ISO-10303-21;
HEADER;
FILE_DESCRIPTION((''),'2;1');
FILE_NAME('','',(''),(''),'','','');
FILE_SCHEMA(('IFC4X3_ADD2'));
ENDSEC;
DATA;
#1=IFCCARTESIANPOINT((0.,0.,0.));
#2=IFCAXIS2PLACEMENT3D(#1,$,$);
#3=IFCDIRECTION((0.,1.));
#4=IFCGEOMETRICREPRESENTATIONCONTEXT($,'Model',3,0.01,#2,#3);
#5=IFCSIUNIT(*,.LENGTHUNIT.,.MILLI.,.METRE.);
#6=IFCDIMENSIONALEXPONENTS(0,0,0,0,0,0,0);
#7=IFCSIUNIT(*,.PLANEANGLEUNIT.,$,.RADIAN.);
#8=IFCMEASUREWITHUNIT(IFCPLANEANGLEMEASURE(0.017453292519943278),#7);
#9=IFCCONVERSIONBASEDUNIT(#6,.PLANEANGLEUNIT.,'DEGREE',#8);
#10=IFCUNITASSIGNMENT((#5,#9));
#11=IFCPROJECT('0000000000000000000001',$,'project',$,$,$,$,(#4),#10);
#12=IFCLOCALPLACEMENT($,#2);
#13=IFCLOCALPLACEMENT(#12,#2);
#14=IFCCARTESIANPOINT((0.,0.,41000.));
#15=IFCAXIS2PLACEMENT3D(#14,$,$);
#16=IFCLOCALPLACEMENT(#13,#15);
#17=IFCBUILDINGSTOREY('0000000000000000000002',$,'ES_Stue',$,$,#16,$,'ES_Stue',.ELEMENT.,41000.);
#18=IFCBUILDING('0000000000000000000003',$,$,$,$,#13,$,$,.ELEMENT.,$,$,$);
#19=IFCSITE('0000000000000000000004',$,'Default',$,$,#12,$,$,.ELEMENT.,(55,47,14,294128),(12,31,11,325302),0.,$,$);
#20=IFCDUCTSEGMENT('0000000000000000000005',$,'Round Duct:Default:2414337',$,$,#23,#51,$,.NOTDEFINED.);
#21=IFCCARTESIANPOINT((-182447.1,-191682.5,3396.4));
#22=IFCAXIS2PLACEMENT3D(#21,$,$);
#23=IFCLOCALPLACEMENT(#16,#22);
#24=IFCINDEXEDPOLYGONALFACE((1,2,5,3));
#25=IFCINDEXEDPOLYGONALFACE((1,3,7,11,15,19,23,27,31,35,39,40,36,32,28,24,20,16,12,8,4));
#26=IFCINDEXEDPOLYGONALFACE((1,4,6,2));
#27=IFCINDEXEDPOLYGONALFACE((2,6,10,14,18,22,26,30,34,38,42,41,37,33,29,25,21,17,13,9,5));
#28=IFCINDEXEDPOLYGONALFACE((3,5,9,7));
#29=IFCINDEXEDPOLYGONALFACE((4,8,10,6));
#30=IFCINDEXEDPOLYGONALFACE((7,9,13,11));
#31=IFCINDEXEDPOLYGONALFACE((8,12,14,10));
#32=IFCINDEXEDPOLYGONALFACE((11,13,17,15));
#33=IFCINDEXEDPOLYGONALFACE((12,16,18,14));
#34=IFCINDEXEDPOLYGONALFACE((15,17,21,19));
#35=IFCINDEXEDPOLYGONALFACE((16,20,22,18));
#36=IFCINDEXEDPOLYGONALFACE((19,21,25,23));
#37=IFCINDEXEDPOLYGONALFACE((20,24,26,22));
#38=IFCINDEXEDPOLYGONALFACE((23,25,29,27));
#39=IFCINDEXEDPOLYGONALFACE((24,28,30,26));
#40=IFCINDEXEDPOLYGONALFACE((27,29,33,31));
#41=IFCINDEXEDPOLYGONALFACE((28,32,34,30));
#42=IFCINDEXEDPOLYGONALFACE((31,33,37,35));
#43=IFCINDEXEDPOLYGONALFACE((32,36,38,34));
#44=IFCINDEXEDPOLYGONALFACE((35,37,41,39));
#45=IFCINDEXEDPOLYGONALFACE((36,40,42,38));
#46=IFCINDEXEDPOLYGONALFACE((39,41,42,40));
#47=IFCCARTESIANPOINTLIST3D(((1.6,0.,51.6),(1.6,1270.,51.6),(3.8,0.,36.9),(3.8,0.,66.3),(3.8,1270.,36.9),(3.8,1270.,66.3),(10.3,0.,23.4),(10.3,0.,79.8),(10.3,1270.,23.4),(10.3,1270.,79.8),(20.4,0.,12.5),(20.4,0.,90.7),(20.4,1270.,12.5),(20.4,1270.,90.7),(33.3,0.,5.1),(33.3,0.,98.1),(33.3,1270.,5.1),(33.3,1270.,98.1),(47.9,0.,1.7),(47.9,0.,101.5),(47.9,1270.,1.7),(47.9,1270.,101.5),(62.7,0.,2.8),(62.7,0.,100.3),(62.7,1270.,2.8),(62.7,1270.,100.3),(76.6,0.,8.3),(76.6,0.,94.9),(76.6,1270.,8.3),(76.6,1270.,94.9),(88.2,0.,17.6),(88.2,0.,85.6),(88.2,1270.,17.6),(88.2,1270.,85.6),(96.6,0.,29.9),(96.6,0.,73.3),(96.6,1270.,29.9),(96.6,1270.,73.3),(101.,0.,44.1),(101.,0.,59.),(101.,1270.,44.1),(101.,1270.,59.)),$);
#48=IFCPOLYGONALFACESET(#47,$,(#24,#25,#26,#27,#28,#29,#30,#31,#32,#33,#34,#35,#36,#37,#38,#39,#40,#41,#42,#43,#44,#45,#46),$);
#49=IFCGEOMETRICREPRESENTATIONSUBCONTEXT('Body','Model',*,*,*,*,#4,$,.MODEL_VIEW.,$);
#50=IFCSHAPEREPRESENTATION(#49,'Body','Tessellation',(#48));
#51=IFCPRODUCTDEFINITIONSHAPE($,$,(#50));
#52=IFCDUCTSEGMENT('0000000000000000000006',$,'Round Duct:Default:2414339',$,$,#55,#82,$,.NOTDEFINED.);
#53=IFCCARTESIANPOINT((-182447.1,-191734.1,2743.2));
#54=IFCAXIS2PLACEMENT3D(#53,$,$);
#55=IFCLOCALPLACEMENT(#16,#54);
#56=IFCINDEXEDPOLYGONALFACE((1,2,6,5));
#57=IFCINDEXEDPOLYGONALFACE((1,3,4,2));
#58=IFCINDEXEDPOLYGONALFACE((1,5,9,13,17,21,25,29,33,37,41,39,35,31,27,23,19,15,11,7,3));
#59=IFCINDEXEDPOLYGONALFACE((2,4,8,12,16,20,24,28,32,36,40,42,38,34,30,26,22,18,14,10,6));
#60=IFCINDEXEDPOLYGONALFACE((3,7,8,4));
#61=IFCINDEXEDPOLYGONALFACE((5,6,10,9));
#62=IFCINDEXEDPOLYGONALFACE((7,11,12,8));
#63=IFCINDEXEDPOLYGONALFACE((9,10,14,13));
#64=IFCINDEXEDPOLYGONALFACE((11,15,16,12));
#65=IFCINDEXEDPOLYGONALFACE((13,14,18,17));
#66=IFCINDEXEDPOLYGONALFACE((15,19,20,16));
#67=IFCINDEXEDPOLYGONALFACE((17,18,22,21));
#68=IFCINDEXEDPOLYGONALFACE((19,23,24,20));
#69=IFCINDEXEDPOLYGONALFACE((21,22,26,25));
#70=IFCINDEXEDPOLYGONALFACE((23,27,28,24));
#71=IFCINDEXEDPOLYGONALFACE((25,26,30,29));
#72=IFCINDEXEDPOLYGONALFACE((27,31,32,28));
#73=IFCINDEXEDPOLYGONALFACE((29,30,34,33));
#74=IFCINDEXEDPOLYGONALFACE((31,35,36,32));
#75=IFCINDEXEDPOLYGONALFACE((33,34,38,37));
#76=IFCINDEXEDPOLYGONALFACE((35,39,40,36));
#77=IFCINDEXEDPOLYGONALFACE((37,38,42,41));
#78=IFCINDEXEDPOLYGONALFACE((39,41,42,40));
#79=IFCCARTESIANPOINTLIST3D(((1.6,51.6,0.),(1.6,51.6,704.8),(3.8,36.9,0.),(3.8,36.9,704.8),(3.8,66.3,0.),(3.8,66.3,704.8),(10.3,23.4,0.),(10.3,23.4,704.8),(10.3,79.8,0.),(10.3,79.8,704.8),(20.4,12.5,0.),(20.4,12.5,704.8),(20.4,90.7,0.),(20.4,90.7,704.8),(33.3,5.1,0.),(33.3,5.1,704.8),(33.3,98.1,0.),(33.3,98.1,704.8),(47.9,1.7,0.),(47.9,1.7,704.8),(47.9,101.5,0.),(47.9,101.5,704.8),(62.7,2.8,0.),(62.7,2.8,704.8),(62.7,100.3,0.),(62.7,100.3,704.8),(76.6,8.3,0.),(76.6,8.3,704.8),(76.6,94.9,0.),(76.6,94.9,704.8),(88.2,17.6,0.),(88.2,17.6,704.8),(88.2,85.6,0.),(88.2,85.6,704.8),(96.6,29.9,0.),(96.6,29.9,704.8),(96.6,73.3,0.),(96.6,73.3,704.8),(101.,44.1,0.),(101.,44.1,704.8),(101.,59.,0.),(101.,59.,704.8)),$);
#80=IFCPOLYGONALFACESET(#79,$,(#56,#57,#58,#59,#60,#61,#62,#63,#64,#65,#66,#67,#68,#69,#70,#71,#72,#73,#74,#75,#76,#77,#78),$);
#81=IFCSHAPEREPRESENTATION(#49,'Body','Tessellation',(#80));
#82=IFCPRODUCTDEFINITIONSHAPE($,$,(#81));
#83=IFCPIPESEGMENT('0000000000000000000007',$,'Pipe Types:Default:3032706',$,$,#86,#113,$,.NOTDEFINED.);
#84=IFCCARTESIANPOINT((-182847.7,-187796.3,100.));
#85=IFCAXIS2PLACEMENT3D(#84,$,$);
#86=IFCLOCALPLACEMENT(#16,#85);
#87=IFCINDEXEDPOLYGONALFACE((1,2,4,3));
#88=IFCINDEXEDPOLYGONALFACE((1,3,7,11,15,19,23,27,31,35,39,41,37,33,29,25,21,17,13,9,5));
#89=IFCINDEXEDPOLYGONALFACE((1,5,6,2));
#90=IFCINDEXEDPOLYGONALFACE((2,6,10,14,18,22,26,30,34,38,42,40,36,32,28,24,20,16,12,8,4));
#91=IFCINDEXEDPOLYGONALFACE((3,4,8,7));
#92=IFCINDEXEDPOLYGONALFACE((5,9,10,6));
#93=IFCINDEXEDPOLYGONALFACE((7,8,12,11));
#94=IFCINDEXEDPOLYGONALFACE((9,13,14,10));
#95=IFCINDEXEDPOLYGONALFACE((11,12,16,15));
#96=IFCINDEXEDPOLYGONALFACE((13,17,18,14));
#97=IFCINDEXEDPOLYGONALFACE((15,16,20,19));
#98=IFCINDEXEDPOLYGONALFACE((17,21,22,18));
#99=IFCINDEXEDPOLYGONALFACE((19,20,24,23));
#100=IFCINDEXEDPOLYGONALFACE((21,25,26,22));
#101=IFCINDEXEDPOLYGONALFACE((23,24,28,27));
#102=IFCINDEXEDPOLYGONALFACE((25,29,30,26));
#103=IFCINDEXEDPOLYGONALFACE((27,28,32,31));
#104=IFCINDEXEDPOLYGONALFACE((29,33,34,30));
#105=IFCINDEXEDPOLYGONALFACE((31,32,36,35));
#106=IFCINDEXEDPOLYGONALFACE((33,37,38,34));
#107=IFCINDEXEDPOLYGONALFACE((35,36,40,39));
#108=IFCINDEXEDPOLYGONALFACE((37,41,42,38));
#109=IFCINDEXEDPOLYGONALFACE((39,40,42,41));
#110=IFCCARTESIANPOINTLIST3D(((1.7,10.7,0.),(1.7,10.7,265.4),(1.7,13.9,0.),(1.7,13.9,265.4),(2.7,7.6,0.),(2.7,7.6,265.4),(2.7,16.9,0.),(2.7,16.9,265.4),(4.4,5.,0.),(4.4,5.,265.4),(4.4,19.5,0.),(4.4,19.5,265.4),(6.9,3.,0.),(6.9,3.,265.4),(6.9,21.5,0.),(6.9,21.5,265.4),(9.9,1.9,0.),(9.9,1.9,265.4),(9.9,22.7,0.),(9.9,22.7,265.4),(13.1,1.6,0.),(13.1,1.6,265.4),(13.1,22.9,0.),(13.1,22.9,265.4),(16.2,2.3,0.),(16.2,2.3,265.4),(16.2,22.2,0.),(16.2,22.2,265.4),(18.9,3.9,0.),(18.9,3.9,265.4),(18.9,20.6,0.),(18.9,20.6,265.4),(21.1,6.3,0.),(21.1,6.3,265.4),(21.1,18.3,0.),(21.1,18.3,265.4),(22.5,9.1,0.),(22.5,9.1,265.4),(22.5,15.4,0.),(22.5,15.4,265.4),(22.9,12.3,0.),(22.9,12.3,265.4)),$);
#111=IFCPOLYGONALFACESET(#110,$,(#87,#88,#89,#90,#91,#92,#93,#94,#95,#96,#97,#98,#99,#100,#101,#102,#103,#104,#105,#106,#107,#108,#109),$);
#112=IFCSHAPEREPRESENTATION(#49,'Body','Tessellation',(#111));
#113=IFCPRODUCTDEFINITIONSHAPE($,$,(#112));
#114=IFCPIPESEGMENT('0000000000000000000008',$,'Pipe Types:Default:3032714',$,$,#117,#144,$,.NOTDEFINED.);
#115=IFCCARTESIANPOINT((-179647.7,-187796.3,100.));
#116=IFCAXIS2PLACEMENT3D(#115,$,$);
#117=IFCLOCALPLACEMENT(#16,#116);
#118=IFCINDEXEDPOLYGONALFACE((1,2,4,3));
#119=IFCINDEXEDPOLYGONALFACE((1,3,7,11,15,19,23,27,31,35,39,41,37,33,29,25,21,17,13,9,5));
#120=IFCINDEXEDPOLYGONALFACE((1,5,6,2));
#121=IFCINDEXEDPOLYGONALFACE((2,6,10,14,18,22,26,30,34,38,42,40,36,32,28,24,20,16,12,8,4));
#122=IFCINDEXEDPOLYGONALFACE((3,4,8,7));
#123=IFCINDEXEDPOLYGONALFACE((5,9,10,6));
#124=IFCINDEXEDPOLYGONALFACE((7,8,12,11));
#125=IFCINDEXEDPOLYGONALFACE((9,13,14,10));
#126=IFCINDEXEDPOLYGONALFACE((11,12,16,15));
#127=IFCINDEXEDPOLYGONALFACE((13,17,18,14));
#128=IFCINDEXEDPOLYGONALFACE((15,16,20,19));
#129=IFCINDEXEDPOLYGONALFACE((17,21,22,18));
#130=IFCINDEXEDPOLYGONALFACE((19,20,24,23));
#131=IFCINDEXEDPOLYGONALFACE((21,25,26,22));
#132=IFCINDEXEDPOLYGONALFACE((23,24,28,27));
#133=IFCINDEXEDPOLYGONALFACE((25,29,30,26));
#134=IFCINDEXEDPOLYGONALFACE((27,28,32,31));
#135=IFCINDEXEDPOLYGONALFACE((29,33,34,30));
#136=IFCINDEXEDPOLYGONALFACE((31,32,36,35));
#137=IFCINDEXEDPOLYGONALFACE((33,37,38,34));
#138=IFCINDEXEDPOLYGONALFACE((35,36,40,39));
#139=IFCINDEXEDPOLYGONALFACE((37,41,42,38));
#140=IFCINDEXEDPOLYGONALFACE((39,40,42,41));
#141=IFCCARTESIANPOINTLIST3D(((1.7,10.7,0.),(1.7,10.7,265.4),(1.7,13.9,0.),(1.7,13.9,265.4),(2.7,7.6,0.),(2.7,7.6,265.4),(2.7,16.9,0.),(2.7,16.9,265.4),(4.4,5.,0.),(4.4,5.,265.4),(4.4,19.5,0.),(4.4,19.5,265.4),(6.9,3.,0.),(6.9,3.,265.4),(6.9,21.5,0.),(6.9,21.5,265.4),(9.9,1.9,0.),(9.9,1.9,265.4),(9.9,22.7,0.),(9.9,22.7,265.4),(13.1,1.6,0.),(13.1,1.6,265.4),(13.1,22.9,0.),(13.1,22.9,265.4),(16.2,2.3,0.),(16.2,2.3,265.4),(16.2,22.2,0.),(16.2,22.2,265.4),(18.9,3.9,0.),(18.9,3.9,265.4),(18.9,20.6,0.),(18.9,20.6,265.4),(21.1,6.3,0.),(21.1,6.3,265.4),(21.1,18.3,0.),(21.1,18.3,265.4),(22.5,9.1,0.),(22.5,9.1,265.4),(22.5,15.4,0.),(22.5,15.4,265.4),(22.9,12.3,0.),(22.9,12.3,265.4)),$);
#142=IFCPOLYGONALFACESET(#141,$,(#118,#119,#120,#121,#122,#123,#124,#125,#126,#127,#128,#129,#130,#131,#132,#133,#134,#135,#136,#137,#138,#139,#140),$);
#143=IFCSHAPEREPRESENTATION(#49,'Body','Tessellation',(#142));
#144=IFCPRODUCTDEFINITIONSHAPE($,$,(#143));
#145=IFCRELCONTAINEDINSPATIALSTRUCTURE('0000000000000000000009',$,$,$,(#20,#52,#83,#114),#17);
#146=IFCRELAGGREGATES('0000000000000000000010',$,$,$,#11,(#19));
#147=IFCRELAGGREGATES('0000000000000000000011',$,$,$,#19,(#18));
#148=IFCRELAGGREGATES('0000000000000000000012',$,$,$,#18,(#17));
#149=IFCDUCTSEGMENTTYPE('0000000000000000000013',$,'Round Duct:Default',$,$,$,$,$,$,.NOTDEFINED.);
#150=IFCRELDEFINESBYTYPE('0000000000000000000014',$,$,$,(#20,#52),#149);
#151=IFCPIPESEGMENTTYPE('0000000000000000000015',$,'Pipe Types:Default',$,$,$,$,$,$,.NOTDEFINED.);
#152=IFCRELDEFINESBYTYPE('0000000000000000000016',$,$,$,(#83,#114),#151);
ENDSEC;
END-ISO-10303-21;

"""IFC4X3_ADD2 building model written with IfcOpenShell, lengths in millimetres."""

from ifc_helpers import new_model, entity, si_unit, converted_unit, direction, frame, origin, origin_2d_with_axis, place, context, subcontext, project, spatial, circle, extrude, type_object, element, save


model = new_model("IFC4X3_ADD2")

# Units and contexts
model_context = context("Model", 3, precision=0.01, world=origin(), true_north=direction((0.0, 1.0)))
body_context = subcontext(model_context, "Body", "Model", "MODEL_VIEW")
ifc_project = project(units=[si_unit("LENGTHUNIT", "METRE", prefix="MILLI"), converted_unit("PLANEANGLEUNIT", "DEGREE", entity("IfcPlaneAngleMeasure", 0.017453292519943278), si_unit("PLANEANGLEUNIT", "RADIAN"), dimensions=[0, 0, 0, 0, 0, 0, 0])], contexts=[model_context])

# Site, building, storey
site_placement = place(None, origin())
site = spatial("IfcSite", under=ifc_project, at=site_placement, Name="Default", CompositionType="ELEMENT", RefLatitude=(55, 47, 14, 294128), RefLongitude=(12, 31, 11, 325302), RefElevation=0.0)
building_placement = place(site_placement, origin())
building = spatial("IfcBuilding", under=site, at=building_placement, CompositionType="ELEMENT")
storey_placement = place(building_placement, frame((0.0, 0.0, 41000.0)))
storey = spatial("IfcBuildingStorey", under=building, at=storey_placement, Name="ES_Stue", LongName="ES_Stue", CompositionType="ELEMENT", Elevation=41000.0)

# Duct segments
duct_segment_type = type_object("IfcDuctSegmentType", Name="Round Duct:Default", PredefinedType="NOTDEFINED")
duct_segment_1_placement = place(storey_placement, frame((-182447.1, -191682.5, 3396.4)))
element("IfcDuctSegment", 1, at=duct_segment_1_placement, inside=storey, type_object=duct_segment_type, Name="Round Duct:Default:2414337", PredefinedType="NOTDEFINED", context=body_context, shape_type="SweptSolid", body=[
    extrude(circle(Radius=50.0, at=origin_2d_with_axis()), frame((51.6, 0.0, 51.6), z_axis=(0.0, 1.0, 0.0), x_axis=(-1.0, 0.0, 0.0)), (0.0, 0.0, 1.0), 1270.0),
])
duct_segment_2_placement = place(storey_placement, frame((-182447.1, -191734.1, 2743.2)))
element("IfcDuctSegment", 2, at=duct_segment_2_placement, inside=storey, type_object=duct_segment_type, Name="Round Duct:Default:2414339", PredefinedType="NOTDEFINED", context=body_context, shape_type="SweptSolid", body=[
    extrude(circle(Radius=50.0, at=origin_2d_with_axis()), frame((51.6, 51.6, 0.0), z_axis=(0.0, 0.0, 1.0), x_axis=(-1.0, 0.0, 0.0)), (0.0, 0.0, 1.0), 704.8),
])

# Pipe segments
pipe_segment_type = type_object("IfcPipeSegmentType", Name="Pipe Types:Default", PredefinedType="NOTDEFINED")
for number, where, name in (
    (3, (-182847.7, -187796.3, 100.0), "Pipe Types:Default:3032706"),
    (4, (-179647.7, -187796.3, 100.0), "Pipe Types:Default:3032714"),
):
    element("IfcPipeSegment", number, at=place(storey_placement, frame(where)), inside=storey, type_object=pipe_segment_type, Name=name, PredefinedType="NOTDEFINED", context=body_context, shape_type="SweptSolid", body=[
        extrude(circle(Radius=10.7, at=origin_2d_with_axis()), frame((12.3, 12.3, 0.0)), (0.0, 0.0, 1.0), 265.4),
    ])

save(model, "model.ifc")
